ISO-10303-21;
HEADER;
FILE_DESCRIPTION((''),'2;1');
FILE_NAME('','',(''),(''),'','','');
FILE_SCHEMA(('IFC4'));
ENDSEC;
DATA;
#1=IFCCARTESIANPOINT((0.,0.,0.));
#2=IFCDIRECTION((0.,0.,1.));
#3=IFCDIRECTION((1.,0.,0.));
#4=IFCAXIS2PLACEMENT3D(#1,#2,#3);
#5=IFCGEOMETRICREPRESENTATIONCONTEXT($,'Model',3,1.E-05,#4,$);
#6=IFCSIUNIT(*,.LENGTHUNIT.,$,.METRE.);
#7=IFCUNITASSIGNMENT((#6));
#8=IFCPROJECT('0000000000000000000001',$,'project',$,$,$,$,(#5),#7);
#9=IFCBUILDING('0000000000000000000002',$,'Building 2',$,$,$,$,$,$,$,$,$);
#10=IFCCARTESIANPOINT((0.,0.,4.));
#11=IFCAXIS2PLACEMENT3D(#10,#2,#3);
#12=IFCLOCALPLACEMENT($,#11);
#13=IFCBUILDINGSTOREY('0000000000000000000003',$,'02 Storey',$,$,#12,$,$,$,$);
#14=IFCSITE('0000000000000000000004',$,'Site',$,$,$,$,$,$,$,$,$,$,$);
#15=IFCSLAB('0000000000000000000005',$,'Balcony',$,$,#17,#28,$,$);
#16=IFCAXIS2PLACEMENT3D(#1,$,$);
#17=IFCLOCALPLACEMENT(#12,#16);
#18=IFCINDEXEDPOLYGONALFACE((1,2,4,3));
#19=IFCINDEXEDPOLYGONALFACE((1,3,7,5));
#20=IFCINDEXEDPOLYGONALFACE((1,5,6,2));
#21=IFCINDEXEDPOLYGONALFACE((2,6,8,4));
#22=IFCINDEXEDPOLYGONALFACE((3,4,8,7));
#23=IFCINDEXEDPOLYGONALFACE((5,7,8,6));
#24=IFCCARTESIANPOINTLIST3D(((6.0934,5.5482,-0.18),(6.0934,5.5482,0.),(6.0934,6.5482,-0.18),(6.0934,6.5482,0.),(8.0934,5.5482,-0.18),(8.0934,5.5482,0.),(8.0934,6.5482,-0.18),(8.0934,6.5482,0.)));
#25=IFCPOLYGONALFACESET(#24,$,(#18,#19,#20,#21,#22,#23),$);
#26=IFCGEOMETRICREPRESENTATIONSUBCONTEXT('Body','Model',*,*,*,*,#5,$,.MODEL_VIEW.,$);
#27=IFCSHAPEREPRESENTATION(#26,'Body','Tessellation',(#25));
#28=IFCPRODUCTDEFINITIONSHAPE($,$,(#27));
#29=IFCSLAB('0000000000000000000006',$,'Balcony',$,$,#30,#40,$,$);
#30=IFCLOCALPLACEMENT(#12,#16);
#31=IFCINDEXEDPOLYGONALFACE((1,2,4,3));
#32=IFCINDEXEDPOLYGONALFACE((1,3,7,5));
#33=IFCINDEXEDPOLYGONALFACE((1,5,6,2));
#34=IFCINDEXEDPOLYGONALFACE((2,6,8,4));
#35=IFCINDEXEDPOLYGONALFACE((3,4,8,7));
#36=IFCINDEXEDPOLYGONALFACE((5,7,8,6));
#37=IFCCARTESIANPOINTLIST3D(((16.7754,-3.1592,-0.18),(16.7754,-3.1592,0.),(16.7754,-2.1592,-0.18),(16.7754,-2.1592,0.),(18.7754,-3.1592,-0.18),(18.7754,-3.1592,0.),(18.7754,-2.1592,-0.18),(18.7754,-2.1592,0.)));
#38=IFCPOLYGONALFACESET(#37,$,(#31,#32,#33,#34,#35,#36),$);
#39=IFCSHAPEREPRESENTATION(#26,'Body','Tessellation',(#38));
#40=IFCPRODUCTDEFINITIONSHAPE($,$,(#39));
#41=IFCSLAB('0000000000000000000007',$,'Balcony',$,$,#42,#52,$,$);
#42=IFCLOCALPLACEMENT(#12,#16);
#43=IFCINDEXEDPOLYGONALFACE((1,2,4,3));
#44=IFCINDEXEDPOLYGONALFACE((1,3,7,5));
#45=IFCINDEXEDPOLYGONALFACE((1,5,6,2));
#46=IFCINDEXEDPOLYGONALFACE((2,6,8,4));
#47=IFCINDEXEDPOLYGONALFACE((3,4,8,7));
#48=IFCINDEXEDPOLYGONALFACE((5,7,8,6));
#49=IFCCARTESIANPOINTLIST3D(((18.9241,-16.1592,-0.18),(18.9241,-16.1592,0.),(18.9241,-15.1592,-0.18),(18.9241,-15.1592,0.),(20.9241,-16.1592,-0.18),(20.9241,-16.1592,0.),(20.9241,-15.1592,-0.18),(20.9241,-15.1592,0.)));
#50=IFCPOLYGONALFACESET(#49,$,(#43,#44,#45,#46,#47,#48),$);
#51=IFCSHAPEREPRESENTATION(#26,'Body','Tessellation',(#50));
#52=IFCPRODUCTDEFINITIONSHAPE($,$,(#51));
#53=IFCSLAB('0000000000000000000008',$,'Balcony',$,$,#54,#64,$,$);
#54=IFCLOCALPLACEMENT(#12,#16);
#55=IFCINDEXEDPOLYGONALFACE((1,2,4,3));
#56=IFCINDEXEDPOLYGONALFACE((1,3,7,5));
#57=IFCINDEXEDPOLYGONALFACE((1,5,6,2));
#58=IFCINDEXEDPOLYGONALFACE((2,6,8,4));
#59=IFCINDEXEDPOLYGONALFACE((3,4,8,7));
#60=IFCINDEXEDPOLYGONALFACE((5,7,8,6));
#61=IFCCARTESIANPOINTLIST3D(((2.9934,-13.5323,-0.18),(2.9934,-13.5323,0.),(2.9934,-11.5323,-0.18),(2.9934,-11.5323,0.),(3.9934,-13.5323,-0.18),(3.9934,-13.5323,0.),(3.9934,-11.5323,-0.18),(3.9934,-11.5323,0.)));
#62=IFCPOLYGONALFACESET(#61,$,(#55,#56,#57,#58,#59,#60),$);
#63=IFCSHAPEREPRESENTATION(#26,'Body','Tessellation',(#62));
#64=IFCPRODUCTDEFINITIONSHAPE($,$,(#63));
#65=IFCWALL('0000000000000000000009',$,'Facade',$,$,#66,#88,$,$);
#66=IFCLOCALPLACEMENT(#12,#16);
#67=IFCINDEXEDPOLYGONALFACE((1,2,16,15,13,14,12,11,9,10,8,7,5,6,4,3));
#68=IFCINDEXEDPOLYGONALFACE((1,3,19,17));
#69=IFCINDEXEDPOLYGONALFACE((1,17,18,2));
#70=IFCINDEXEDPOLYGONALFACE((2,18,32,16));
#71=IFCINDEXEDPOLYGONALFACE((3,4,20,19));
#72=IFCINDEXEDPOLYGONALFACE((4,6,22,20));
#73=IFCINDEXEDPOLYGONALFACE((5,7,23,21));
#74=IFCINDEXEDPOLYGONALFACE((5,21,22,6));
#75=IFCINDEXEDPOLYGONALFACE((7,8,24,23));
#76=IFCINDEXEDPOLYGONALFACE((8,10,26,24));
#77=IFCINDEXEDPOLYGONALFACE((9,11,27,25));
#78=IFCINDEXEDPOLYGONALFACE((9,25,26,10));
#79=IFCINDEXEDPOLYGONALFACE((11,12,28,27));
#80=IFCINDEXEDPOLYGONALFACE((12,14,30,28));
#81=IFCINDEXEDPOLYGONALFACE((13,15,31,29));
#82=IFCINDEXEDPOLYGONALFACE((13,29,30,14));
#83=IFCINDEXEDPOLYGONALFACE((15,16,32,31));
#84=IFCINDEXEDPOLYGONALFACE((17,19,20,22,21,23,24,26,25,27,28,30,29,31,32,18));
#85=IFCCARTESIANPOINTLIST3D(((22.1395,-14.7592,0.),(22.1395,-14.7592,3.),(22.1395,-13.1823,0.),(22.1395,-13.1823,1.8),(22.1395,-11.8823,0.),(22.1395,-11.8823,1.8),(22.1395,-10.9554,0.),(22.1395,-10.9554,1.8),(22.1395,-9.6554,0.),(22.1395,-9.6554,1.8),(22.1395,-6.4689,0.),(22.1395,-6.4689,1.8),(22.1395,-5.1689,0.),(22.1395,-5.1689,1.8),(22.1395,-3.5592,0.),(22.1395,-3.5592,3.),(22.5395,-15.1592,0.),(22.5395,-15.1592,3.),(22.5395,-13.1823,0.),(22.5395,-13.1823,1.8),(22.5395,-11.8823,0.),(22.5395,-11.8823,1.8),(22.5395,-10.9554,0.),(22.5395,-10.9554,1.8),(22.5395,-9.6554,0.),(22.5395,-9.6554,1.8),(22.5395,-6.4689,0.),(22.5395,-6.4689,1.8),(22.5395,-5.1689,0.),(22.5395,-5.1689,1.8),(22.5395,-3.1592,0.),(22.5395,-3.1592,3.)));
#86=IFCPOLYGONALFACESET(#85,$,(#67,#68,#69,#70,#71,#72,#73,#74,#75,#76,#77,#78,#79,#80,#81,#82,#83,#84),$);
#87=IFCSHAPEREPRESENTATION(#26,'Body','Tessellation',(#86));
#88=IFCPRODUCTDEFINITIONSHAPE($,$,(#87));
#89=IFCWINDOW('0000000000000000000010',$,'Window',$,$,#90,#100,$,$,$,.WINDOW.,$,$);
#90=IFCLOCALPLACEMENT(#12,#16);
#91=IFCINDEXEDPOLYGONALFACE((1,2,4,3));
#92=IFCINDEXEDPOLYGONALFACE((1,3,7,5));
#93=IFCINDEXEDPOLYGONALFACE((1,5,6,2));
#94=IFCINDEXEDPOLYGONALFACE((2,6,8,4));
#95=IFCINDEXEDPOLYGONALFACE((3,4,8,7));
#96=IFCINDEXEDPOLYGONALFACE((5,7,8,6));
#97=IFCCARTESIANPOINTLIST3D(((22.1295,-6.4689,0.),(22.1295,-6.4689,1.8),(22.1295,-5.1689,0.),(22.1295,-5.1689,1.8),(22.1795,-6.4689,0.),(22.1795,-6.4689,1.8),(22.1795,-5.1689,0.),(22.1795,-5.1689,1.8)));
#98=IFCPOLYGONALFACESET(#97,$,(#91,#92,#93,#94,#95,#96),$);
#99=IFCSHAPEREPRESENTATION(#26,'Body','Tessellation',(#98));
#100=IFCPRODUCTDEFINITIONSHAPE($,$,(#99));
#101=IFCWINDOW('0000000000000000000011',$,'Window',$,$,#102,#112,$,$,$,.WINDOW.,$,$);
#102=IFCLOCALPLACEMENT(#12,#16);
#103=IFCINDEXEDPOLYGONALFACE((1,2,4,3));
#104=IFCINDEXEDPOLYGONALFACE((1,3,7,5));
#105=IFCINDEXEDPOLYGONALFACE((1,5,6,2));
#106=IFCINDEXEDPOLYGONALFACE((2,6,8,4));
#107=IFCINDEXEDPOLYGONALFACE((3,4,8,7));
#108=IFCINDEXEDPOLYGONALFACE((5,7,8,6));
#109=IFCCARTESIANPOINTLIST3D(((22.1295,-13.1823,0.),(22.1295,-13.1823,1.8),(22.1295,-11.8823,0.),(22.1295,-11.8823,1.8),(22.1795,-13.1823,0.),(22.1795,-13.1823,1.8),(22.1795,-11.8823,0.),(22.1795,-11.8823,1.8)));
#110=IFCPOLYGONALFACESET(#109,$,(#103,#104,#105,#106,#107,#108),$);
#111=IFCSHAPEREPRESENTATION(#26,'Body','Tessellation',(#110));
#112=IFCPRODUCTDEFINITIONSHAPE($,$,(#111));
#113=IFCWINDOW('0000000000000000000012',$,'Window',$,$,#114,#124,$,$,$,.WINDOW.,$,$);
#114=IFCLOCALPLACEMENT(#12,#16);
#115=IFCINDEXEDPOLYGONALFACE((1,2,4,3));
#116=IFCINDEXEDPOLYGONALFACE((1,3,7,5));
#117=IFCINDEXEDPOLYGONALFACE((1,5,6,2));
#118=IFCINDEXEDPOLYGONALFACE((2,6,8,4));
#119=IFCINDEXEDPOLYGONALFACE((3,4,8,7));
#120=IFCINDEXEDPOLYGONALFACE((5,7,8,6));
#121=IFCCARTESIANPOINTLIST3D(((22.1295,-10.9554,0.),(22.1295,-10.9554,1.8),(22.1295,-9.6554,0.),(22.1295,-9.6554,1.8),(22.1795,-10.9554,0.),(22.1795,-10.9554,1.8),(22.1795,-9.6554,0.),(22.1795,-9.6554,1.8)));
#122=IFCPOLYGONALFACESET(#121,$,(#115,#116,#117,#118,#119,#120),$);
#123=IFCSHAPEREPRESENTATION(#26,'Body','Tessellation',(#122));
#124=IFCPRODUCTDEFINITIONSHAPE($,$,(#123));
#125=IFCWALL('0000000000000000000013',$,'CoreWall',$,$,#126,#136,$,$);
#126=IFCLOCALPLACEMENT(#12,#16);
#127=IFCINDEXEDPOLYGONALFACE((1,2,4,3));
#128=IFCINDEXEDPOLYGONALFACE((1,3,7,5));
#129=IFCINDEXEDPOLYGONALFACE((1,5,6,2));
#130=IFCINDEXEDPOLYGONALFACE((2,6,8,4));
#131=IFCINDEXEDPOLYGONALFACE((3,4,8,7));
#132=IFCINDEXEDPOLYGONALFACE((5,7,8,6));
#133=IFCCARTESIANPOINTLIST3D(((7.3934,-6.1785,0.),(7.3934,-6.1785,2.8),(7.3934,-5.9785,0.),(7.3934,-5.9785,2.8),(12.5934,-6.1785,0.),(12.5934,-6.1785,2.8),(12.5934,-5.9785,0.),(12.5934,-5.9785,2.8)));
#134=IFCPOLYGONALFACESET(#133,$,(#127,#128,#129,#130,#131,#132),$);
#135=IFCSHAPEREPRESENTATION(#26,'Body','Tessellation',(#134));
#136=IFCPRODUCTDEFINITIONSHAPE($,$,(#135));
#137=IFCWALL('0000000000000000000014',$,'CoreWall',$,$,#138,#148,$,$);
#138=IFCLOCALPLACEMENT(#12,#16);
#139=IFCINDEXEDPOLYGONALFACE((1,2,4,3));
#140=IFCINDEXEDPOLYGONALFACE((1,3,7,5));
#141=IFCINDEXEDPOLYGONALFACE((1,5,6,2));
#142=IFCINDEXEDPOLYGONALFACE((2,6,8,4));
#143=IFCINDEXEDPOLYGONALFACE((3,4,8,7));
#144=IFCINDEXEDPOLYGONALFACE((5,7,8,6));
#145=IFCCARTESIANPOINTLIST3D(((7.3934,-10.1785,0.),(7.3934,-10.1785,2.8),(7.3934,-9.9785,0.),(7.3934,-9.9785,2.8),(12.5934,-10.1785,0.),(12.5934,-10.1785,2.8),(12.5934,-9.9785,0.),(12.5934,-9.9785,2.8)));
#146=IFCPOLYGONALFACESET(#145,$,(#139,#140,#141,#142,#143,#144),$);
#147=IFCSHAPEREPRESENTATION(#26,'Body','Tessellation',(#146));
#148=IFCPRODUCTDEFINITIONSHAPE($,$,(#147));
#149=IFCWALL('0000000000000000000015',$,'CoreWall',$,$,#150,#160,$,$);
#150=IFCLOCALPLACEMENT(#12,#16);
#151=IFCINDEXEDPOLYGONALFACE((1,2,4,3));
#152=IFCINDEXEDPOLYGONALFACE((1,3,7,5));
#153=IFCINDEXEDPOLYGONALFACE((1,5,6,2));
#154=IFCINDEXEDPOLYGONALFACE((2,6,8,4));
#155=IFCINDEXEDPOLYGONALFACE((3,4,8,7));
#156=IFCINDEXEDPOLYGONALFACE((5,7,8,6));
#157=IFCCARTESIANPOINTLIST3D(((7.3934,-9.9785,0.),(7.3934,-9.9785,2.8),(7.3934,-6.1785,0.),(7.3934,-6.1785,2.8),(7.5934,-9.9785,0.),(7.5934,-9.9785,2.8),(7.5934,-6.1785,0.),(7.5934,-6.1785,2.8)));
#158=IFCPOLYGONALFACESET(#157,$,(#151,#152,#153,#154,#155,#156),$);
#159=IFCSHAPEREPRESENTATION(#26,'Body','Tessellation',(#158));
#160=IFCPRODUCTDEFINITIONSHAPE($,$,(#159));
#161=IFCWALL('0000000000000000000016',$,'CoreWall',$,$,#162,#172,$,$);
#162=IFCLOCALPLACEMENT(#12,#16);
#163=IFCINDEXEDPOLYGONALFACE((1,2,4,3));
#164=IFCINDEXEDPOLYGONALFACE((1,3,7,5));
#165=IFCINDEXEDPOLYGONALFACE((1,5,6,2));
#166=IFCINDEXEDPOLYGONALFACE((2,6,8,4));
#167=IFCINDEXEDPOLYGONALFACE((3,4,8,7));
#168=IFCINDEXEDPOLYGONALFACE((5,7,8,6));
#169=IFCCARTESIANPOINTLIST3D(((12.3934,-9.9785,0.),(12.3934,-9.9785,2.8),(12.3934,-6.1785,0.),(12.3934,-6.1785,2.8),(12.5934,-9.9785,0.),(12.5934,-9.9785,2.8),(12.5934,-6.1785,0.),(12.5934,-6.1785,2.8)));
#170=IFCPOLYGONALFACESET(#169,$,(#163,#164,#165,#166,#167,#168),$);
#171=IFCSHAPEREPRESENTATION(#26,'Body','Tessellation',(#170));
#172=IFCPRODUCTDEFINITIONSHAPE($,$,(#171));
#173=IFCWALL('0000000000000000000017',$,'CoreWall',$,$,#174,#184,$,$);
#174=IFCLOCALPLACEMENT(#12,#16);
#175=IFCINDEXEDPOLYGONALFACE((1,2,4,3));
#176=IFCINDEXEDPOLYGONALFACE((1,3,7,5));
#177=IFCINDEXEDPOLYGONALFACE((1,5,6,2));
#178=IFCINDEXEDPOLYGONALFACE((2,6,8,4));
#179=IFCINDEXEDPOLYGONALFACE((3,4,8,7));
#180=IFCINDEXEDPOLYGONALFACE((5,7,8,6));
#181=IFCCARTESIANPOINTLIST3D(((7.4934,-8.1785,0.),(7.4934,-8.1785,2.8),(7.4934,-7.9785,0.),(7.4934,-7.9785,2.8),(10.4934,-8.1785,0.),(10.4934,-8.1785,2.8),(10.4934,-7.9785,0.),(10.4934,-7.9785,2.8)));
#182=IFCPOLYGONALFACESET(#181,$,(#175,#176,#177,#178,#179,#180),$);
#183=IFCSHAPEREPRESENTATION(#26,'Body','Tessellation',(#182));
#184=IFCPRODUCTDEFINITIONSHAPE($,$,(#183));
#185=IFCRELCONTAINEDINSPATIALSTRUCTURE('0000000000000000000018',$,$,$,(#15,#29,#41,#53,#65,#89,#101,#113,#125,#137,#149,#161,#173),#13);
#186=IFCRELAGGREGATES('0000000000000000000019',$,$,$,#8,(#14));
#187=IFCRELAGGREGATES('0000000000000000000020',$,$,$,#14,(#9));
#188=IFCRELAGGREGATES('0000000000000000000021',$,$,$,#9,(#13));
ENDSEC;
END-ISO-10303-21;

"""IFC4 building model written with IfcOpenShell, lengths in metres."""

from ifc_helpers import new_model, si_unit, frame, origin_with_axes, place, context, subcontext, project, spatial, line, indexed_curve, outline, extrude, element, fill, save


model = new_model("IFC4")

# Units and contexts
model_context = context("Model", 3, precision=1e-05, world=origin_with_axes())
body_context = subcontext(model_context, "Body", "Model", "MODEL_VIEW")
ifc_project = project(units=[si_unit("LENGTHUNIT", "METRE")], contexts=[model_context])

# Site, building, storey
site = spatial("IfcSite", under=ifc_project, Name="Site")
building = spatial("IfcBuilding", under=site, Name="Building 2")
storey_placement = place(None, frame((0.0, 0.0, 4.0), z_axis=(0.0, 0.0, 1.0), x_axis=(1.0, 0.0, 0.0)))
storey = spatial("IfcBuildingStorey", under=building, at=storey_placement, Name="02 Storey")

# Slabs
slab_1_placement = place(storey_placement, origin_with_axes())
element("IfcSlab", 1, at=slab_1_placement, inside=storey, Name="Balcony", context=body_context, shape_type="SweptSolid", body=[
    extrude(outline(indexed_curve([(6.0934, 5.5482), (6.0934, 6.5482), (8.0934, 6.5482), (8.0934, 5.5482)], segments=[line(1, 2), line(2, 3), line(3, 4)])), origin_with_axes(), (0.0, 0.0, -1.0), 0.18),
])
slab_2_placement = place(storey_placement, origin_with_axes())
element("IfcSlab", 2, at=slab_2_placement, inside=storey, Name="Balcony", context=body_context, shape_type="SweptSolid", body=[
    extrude(outline(indexed_curve([(16.7754, -3.1592), (16.7754, -2.1592), (18.7754, -2.1592), (18.7754, -3.1592)], segments=[line(1, 2), line(2, 3), line(3, 4)])), origin_with_axes(), (0.0, 0.0, -1.0), 0.18),
])
slab_3_placement = place(storey_placement, origin_with_axes())
element("IfcSlab", 3, at=slab_3_placement, inside=storey, Name="Balcony", context=body_context, shape_type="SweptSolid", body=[
    extrude(outline(indexed_curve([(20.9241, -15.1592), (20.9241, -16.1592), (18.9241, -16.1592), (18.9241, -15.1592)], segments=[line(1, 2), line(2, 3), line(3, 4)])), origin_with_axes(), (0.0, 0.0, -1.0), 0.18),
])
slab_4_placement = place(storey_placement, origin_with_axes())
element("IfcSlab", 4, at=slab_4_placement, inside=storey, Name="Balcony", context=body_context, shape_type="SweptSolid", body=[
    extrude(outline(indexed_curve([(3.9934, -13.5323), (2.9934, -13.5323), (2.9934, -11.5323), (3.9934, -11.5323)], segments=[line(1, 2), line(2, 3), line(3, 4)])), origin_with_axes(), (0.0, 0.0, -1.0), 0.18),
])

# Wall, openings, windows
wall_1_placement = place(storey_placement, origin_with_axes())
wall_1 = element("IfcWall", 5, at=wall_1_placement, inside=storey, Name="Facade", context=body_context, shape_type="SweptSolid", body=[
    extrude(outline(indexed_curve([(22.1395, -14.7592), (22.1395, -3.5592), (22.5395, -3.1592), (22.5395, -15.1592)], segments=[line(1, 2), line(2, 3), line(3, 4)])), origin_with_axes(), (0.0, 0.0, 1.0), 3.0),
])
opening_1_placement = place(wall_1_placement, origin_with_axes())
opening_1 = element("IfcOpeningElement", 6, at=opening_1_placement, cuts=wall_1, context=body_context, shape_type="SweptSolid", body=[
    extrude(outline(indexed_curve([(22.5795, -6.4689), (22.0795, -6.4689), (22.0795, -5.1689), (22.5795, -5.1689)], segments=[line(1, 2), line(2, 3), line(3, 4)])), origin_with_axes(), (0.0, 0.0, 1.0), 1.8),
])
opening_2_placement = place(wall_1_placement, origin_with_axes())
opening_2 = element("IfcOpeningElement", 7, at=opening_2_placement, cuts=wall_1, context=body_context, shape_type="SweptSolid", body=[
    extrude(outline(indexed_curve([(22.5795, -13.1823), (22.0795, -13.1823), (22.0795, -11.8823), (22.5795, -11.8823)], segments=[line(1, 2), line(2, 3), line(3, 4)])), origin_with_axes(), (0.0, 0.0, 1.0), 1.8),
])
opening_3_placement = place(wall_1_placement, origin_with_axes())
opening_3 = element("IfcOpeningElement", 8, at=opening_3_placement, cuts=wall_1, context=body_context, shape_type="SweptSolid", body=[
    extrude(outline(indexed_curve([(22.5795, -10.9554), (22.0795, -10.9554), (22.0795, -9.6554), (22.5795, -9.6554)], segments=[line(1, 2), line(2, 3), line(3, 4)])), origin_with_axes(), (0.0, 0.0, 1.0), 1.8),
])
window_1_placement = place(storey_placement, origin_with_axes())
window_1 = element("IfcWindow", 9, at=window_1_placement, inside=storey, Name="Window", PredefinedType="WINDOW", context=body_context, shape_type="SweptSolid", body=[
    extrude(outline(indexed_curve([(22.1795, -6.4689), (22.1295, -6.4689), (22.1295, -5.1689), (22.1795, -5.1689)], segments=[line(1, 2), line(2, 3), line(3, 4)])), origin_with_axes(), (0.0, 0.0, 1.0), 1.8),
])
fill(opening_1, window_1)
window_2_placement = place(storey_placement, origin_with_axes())
window_2 = element("IfcWindow", 10, at=window_2_placement, inside=storey, Name="Window", PredefinedType="WINDOW", context=body_context, shape_type="SweptSolid", body=[
    extrude(outline(indexed_curve([(22.1795, -13.1823), (22.1295, -13.1823), (22.1295, -11.8823), (22.1795, -11.8823)], segments=[line(1, 2), line(2, 3), line(3, 4)])), origin_with_axes(), (0.0, 0.0, 1.0), 1.8),
])
fill(opening_2, window_2)
window_3_placement = place(storey_placement, origin_with_axes())
window_3 = element("IfcWindow", 11, at=window_3_placement, inside=storey, Name="Window", PredefinedType="WINDOW", context=body_context, shape_type="SweptSolid", body=[
    extrude(outline(indexed_curve([(22.1795, -10.9554), (22.1295, -10.9554), (22.1295, -9.6554), (22.1795, -9.6554)], segments=[line(1, 2), line(2, 3), line(3, 4)])), origin_with_axes(), (0.0, 0.0, 1.0), 1.8),
])
fill(opening_3, window_3)

# Walls
wall_2_placement = place(storey_placement, origin_with_axes())
element("IfcWall", 12, at=wall_2_placement, inside=storey, Name="CoreWall", context=body_context, shape_type="SweptSolid", body=[
    extrude(outline(indexed_curve([(12.5934, -5.9785), (7.3934, -5.9785), (7.3934, -6.1785), (12.5934, -6.1785)], segments=[line(1, 2), line(2, 3), line(3, 4)])), origin_with_axes(), (0.0, 0.0, 1.0), 2.8),
])
wall_3_placement = place(storey_placement, origin_with_axes())
element("IfcWall", 13, at=wall_3_placement, inside=storey, Name="CoreWall", context=body_context, shape_type="SweptSolid", body=[
    extrude(outline(indexed_curve([(7.3934, -10.1785), (12.5934, -10.1785), (12.5934, -9.9785), (7.3934, -9.9785)], segments=[line(1, 2), line(2, 3), line(3, 4)])), origin_with_axes(), (0.0, 0.0, 1.0), 2.8),
])
wall_4_placement = place(storey_placement, origin_with_axes())
element("IfcWall", 14, at=wall_4_placement, inside=storey, Name="CoreWall", context=body_context, shape_type="SweptSolid", body=[
    extrude(outline(indexed_curve([(7.5934, -9.9785), (7.5934, -6.1785), (7.3934, -6.1785), (7.3934, -9.9785)], segments=[line(1, 2), line(2, 3), line(3, 4)])), origin_with_axes(), (0.0, 0.0, 1.0), 2.8),
])
wall_5_placement = place(storey_placement, origin_with_axes())
element("IfcWall", 15, at=wall_5_placement, inside=storey, Name="CoreWall", context=body_context, shape_type="SweptSolid", body=[
    extrude(outline(indexed_curve([(12.3934, -6.1785), (12.3934, -9.9785), (12.5934, -9.9785), (12.5934, -6.1785)], segments=[line(1, 2), line(2, 3), line(3, 4)])), origin_with_axes(), (0.0, 0.0, 1.0), 2.8),
])
wall_6_placement = place(storey_placement, origin_with_axes())
element("IfcWall", 16, at=wall_6_placement, inside=storey, Name="CoreWall", context=body_context, shape_type="SweptSolid", body=[
    extrude(outline(indexed_curve([(10.4934, -7.9785), (7.4934, -7.9785), (7.4934, -8.1785), (10.4934, -8.1785)], segments=[line(1, 2), line(2, 3), line(3, 4)])), origin_with_axes(), (0.0, 0.0, 1.0), 2.8),
])

save(model, "model.ifc")
